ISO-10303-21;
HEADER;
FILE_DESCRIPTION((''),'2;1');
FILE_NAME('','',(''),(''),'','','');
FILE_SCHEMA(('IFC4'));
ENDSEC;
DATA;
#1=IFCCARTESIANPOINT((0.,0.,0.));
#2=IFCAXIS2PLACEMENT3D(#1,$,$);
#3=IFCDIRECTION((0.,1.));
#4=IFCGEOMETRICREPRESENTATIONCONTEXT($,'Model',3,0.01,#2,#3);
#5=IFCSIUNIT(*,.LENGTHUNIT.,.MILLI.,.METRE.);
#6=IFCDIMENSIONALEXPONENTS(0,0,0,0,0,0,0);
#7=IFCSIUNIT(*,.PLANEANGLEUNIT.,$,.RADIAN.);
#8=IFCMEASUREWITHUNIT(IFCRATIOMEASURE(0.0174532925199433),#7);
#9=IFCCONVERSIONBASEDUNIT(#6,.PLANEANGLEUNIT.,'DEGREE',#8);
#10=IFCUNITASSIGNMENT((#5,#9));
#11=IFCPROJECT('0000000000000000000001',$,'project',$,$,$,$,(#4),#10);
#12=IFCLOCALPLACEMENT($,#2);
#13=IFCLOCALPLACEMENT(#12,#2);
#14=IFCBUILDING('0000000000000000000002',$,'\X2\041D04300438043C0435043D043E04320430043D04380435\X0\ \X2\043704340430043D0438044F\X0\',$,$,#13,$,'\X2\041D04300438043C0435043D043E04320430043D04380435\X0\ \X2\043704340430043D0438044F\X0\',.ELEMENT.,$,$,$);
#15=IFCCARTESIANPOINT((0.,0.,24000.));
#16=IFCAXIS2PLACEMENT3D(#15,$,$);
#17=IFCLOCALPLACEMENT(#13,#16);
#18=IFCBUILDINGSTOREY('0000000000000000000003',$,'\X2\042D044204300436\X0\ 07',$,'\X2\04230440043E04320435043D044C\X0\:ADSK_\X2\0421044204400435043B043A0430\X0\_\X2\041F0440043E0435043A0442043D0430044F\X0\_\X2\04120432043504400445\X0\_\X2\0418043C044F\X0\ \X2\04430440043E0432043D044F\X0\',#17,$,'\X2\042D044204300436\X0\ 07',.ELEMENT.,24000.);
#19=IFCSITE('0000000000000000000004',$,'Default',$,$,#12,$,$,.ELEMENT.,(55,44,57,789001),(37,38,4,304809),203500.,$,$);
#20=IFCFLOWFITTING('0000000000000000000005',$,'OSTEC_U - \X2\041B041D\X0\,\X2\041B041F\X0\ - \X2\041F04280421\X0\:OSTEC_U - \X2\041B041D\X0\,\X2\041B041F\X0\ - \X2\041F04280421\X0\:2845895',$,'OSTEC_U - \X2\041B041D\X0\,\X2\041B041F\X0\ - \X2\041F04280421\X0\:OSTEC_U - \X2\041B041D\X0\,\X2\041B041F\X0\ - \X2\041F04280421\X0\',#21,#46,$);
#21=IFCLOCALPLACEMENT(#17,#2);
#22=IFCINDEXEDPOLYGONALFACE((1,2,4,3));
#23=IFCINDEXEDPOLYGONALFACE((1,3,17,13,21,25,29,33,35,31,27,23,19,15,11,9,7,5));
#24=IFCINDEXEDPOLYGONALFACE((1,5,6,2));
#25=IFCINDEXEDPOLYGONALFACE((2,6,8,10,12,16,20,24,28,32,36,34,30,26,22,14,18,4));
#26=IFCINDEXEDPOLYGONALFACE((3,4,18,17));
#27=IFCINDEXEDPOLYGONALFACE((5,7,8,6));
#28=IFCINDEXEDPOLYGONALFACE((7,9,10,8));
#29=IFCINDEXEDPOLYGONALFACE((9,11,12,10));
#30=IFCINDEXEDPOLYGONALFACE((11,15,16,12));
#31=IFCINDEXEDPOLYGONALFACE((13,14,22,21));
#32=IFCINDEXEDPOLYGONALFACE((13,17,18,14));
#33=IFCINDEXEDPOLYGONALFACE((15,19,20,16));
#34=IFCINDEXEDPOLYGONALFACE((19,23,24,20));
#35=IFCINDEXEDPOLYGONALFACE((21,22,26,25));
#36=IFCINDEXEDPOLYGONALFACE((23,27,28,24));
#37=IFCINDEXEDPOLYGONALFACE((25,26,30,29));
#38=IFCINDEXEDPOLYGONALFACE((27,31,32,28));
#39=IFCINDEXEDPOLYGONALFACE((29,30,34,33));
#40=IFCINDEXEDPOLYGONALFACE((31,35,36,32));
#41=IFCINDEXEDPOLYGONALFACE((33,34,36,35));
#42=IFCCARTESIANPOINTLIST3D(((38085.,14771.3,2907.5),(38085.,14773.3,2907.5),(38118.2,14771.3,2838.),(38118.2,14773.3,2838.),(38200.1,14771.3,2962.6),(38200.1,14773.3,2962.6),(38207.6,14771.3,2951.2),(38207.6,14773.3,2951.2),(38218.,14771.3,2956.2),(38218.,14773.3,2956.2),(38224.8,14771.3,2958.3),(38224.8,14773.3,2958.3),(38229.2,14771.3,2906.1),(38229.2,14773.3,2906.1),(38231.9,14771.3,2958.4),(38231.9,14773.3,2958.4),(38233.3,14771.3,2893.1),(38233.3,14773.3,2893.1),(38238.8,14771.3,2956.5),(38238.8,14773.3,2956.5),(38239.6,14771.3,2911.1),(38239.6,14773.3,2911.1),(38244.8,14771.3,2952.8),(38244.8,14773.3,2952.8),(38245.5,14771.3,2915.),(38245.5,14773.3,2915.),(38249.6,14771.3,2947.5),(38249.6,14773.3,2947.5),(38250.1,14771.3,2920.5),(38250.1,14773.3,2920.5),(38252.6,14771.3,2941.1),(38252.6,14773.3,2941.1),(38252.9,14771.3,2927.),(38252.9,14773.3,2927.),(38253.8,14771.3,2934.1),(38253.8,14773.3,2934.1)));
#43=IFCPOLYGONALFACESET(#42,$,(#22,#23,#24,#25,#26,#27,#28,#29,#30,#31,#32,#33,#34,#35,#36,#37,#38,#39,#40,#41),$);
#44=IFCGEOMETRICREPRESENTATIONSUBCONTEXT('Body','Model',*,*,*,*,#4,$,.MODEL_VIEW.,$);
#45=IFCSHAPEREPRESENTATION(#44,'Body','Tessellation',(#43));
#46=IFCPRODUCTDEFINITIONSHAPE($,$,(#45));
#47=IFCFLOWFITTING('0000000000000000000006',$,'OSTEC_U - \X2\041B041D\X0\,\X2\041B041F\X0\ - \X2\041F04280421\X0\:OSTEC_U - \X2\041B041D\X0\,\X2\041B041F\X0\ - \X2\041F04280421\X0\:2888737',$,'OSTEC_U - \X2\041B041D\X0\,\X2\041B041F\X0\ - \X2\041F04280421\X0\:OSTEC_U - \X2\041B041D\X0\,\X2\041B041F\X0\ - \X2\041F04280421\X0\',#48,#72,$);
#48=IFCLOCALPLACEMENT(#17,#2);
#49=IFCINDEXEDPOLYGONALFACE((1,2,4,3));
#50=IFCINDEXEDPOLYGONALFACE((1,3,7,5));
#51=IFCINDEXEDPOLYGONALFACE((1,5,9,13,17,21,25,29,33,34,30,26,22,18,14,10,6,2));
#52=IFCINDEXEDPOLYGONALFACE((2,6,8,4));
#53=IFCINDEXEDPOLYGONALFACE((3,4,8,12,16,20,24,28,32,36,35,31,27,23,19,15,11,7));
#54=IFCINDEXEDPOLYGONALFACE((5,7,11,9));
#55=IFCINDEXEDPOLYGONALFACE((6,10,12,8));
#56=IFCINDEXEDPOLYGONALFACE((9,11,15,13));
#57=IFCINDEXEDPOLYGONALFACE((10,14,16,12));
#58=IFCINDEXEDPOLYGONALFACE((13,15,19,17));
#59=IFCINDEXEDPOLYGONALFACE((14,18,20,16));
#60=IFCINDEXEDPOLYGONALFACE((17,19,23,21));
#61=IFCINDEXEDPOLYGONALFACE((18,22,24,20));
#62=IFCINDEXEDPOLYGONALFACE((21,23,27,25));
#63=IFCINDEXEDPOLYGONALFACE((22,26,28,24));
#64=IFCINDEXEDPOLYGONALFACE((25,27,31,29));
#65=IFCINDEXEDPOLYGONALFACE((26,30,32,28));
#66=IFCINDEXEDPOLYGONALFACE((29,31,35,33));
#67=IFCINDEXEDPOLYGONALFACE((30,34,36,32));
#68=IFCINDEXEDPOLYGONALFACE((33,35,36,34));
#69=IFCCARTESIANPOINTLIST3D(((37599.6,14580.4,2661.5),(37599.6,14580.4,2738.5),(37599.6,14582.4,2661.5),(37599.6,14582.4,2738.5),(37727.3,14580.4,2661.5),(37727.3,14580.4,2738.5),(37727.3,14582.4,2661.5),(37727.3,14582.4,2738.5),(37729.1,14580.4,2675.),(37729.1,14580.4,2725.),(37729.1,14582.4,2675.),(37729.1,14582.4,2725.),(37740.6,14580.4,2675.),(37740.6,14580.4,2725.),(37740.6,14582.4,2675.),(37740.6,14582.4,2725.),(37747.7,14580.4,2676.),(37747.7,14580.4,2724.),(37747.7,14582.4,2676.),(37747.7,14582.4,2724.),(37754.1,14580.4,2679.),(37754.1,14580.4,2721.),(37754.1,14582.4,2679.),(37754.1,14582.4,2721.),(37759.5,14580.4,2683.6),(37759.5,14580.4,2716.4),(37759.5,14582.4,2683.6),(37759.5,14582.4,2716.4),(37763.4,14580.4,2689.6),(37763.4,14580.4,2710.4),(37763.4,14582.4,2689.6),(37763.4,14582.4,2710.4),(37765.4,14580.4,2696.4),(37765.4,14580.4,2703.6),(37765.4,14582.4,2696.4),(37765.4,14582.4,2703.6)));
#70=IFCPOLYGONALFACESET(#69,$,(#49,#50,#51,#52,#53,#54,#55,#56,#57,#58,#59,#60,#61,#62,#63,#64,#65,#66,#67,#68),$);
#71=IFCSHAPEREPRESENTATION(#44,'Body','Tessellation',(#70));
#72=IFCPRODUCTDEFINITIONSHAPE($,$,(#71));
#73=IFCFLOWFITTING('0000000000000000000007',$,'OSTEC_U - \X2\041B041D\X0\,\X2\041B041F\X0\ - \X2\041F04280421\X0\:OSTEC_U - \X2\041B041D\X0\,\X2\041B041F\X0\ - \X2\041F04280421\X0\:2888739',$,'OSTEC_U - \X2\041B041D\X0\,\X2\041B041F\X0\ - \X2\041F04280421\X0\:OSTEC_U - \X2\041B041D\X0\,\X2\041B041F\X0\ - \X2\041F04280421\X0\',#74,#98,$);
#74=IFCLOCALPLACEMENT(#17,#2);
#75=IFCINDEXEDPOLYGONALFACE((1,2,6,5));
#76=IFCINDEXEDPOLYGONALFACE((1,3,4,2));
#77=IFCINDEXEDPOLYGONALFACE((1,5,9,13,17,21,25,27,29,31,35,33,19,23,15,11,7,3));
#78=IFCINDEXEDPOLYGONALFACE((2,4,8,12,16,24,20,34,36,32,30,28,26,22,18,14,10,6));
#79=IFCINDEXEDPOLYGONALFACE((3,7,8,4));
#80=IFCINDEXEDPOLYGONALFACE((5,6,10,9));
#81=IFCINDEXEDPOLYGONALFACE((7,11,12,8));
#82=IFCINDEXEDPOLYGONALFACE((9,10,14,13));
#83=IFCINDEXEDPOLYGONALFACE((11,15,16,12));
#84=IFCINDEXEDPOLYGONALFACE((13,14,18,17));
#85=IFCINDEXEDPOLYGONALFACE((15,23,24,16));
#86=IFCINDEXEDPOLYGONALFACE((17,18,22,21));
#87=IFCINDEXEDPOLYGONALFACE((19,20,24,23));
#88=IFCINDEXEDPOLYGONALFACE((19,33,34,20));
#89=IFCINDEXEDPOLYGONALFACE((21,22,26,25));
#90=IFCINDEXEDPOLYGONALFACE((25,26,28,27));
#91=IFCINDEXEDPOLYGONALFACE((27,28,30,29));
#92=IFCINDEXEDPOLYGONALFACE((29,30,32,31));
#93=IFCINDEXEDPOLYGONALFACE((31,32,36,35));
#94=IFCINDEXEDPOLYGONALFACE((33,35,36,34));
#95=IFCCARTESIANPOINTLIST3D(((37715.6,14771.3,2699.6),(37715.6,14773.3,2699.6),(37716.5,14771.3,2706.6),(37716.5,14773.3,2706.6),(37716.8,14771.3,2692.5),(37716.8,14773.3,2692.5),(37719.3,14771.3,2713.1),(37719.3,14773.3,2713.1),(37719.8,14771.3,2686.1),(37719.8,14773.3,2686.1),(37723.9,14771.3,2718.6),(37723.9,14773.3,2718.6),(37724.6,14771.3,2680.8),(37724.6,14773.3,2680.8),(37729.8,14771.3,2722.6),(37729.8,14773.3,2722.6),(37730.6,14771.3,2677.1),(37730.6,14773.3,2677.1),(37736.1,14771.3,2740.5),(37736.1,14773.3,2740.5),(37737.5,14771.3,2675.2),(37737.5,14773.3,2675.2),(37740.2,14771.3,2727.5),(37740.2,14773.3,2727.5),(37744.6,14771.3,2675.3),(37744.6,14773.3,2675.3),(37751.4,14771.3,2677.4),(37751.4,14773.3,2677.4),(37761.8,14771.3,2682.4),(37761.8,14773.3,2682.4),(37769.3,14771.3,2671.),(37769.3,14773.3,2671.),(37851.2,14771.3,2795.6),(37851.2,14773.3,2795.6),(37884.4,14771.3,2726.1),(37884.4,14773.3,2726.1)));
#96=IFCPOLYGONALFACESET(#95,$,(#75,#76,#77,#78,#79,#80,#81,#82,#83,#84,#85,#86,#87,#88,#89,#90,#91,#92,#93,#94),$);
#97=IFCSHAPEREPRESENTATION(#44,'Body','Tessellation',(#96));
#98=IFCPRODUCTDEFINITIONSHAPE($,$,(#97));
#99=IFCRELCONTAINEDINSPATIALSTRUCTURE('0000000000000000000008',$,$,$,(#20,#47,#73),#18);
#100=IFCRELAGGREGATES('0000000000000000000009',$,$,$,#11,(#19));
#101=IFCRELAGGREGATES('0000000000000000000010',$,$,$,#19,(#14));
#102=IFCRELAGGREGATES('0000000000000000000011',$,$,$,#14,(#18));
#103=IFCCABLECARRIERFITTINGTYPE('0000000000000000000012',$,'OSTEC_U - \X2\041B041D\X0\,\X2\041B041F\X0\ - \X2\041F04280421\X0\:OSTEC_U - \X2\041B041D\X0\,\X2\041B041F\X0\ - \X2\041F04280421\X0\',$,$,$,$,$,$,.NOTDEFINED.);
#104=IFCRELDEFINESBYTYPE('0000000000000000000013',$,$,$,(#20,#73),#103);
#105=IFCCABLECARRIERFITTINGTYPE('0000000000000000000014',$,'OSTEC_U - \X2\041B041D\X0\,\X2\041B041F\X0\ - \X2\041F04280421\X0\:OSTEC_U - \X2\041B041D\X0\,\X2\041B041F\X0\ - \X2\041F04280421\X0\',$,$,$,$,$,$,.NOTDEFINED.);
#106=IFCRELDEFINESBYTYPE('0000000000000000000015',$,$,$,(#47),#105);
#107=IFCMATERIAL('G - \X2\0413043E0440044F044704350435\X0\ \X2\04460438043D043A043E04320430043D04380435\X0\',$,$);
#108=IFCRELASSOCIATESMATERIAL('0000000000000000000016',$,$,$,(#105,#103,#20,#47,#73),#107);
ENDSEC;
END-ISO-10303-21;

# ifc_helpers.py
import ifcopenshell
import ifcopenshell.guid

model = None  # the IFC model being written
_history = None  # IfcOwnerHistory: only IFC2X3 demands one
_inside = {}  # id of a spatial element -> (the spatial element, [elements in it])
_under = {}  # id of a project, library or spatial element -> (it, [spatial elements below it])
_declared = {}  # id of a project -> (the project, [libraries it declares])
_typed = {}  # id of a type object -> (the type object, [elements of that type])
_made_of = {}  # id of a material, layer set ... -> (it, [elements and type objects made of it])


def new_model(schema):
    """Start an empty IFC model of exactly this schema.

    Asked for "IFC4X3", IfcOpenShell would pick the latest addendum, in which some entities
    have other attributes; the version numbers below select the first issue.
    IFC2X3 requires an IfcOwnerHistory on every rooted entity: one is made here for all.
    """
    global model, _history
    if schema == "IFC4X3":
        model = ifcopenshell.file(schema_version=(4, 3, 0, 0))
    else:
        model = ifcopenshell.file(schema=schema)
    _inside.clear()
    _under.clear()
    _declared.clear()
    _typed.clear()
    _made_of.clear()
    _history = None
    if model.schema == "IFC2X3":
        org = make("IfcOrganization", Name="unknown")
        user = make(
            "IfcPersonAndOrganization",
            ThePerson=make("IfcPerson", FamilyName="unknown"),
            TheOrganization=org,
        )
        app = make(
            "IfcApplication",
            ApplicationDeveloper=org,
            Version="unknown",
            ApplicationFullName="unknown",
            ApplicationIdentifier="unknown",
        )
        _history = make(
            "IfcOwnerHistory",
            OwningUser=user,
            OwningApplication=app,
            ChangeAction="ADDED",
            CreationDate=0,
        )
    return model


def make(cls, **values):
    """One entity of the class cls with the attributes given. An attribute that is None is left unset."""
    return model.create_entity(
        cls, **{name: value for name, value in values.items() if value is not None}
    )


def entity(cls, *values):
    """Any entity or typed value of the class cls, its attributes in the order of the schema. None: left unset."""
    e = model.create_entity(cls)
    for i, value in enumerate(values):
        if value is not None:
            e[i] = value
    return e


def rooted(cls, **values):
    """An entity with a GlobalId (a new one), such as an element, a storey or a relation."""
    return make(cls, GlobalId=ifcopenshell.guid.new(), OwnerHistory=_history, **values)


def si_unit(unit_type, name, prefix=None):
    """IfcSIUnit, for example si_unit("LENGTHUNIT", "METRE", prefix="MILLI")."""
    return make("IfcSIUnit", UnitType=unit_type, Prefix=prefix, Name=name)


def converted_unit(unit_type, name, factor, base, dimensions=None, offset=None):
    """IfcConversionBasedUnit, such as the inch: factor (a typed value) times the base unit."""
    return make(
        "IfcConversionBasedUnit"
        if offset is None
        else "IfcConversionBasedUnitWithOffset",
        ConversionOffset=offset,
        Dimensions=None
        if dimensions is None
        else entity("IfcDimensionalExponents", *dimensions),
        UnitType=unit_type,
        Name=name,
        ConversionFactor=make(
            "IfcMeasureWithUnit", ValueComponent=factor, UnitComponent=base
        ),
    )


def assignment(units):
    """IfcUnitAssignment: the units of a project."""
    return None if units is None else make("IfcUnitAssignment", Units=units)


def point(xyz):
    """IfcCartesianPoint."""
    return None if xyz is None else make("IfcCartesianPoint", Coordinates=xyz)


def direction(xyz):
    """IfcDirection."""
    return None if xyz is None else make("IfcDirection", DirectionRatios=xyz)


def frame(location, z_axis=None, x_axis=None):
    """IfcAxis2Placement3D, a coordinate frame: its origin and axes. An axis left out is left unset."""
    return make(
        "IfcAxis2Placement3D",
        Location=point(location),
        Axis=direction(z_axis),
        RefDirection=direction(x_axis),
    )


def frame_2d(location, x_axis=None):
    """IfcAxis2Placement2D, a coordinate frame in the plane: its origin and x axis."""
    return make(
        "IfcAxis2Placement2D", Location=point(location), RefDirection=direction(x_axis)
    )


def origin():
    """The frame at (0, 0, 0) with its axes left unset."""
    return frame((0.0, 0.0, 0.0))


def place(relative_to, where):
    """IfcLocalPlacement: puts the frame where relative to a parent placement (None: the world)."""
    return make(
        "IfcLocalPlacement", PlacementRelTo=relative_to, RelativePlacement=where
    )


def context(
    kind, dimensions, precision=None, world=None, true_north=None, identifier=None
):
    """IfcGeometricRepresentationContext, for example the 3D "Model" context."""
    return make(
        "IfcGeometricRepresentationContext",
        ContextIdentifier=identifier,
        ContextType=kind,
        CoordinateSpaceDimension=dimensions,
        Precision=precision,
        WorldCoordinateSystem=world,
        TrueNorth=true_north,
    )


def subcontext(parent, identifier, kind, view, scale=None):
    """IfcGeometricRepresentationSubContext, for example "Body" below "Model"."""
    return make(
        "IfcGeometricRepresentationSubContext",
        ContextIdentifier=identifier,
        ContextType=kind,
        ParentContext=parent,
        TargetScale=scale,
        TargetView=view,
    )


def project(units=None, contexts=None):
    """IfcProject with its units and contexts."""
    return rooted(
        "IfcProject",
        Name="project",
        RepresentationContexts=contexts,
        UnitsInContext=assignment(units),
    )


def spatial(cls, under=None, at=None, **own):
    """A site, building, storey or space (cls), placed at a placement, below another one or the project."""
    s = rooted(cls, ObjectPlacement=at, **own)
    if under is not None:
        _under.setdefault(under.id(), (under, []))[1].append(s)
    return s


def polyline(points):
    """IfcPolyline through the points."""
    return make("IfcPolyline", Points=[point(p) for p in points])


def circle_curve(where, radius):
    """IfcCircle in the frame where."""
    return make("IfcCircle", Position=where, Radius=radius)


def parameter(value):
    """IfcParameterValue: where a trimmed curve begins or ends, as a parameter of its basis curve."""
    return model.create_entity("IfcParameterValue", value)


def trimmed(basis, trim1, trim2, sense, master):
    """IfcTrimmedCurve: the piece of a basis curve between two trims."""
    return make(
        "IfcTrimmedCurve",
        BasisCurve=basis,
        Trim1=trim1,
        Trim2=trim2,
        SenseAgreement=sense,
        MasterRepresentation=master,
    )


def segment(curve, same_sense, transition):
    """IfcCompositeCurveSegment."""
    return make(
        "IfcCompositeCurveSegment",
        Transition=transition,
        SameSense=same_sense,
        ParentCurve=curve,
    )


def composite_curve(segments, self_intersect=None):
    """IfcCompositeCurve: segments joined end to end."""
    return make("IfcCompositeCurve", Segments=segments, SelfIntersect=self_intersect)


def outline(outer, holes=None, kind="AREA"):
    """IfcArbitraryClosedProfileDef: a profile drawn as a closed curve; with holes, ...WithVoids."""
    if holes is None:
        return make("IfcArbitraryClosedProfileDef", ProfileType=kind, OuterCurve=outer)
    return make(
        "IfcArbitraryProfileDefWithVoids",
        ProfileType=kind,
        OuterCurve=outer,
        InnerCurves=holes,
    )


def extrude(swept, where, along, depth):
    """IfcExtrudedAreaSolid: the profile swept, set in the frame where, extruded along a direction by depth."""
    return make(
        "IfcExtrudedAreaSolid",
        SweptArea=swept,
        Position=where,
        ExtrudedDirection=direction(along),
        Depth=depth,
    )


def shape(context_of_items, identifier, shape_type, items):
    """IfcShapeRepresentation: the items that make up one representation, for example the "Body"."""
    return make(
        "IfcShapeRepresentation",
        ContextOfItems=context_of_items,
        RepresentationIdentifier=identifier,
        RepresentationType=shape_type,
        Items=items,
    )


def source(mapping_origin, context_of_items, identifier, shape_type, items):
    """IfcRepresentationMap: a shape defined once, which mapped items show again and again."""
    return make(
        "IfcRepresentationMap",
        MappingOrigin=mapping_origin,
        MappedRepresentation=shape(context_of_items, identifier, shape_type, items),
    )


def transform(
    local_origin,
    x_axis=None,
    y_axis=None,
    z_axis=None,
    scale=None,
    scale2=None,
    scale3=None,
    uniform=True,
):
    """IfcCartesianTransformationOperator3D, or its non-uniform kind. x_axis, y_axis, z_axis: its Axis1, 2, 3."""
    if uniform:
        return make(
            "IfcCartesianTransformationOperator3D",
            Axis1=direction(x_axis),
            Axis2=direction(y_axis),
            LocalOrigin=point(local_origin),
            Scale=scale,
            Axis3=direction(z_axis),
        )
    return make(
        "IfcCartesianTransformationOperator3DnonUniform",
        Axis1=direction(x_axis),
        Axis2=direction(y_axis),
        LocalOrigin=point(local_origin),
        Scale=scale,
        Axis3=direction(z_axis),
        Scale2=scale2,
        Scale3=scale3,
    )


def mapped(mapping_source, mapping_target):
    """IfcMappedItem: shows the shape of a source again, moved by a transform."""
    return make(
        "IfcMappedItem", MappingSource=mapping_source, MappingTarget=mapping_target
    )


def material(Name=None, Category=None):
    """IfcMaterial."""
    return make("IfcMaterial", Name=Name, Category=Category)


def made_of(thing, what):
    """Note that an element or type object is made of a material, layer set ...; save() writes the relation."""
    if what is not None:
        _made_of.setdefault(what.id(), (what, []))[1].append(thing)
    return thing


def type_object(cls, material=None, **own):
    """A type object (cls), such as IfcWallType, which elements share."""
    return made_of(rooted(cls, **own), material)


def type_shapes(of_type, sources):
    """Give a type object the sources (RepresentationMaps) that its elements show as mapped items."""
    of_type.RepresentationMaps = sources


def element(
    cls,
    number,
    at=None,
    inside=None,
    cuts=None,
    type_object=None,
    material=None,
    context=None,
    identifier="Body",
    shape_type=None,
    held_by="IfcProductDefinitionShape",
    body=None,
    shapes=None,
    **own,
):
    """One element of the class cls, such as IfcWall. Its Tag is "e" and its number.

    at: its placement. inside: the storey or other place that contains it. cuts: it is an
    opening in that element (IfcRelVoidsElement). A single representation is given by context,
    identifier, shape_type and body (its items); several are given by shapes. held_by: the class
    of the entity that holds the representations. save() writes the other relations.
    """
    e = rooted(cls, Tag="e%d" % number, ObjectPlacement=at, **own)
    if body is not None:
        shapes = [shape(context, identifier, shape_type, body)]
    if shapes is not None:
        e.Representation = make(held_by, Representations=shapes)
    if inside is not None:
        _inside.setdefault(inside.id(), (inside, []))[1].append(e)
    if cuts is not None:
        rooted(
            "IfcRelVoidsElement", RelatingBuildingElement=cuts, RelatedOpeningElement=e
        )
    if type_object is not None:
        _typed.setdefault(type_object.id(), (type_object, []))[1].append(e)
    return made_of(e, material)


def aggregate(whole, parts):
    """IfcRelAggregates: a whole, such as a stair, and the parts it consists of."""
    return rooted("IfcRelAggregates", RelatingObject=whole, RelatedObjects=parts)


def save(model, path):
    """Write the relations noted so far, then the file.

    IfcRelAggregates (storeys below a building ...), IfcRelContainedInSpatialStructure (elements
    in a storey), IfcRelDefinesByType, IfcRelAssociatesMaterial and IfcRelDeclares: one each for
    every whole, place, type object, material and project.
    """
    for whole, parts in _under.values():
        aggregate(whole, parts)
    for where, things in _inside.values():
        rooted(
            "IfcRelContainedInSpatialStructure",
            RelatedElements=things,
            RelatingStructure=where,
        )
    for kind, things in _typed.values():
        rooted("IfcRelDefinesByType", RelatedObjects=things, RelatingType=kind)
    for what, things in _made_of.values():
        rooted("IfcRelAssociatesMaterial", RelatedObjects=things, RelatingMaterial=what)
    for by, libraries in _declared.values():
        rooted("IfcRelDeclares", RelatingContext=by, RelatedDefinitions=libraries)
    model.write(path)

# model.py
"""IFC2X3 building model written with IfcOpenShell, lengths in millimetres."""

from ifc_helpers import new_model, entity, si_unit, converted_unit, direction, frame, frame_2d, origin, place, context, subcontext, project, spatial, polyline, circle_curve, parameter, trimmed, segment, composite_curve, outline, extrude, source, transform, mapped, material, type_object, type_shapes, element, save


model = new_model("IFC2X3")

# Units and contexts
model_context = context("Model", 3, precision=0.01, world=origin(), true_north=direction((0.0, 1.0)))
body_context = subcontext(model_context, "Body", "Model", "MODEL_VIEW")
ifc_project = project(units=[si_unit("LENGTHUNIT", "METRE", prefix="MILLI"), converted_unit("PLANEANGLEUNIT", "DEGREE", entity("IfcRatioMeasure", 0.0174532925199433), si_unit("PLANEANGLEUNIT", "RADIAN"), dimensions=[0, 0, 0, 0, 0, 0, 0])], contexts=[model_context])

# Site, building, storey
site_placement = place(None, origin())
site = spatial("IfcSite", under=ifc_project, at=site_placement, Name="Default", CompositionType="ELEMENT", RefLatitude=(55, 44, 57, 789001), RefLongitude=(37, 38, 4, 304809), RefElevation=203500.0)
building_placement = place(site_placement, origin())
building = spatial("IfcBuilding", under=site, at=building_placement, Name="Наименование здания", LongName="Наименование здания", CompositionType="ELEMENT")
storey_placement = place(building_placement, frame((0.0, 0.0, 24000.0)))
storey = spatial("IfcBuildingStorey", under=building, at=storey_placement, Name="Этаж 07", ObjectType="Уровень:ADSK_Стрелка_Проектная_Вверх_Имя уровня", LongName="Этаж 07", CompositionType="ELEMENT", Elevation=24000.0)

# Flow fittings
ifc_material_1 = material(Name="G - Горячее цинкование")
cable_carrier_fitting_type_1 = type_object("IfcCableCarrierFittingType", Name="OSTEC_U - ЛН,ЛП - ПШС:OSTEC_U - ЛН,ЛП - ПШС", PredefinedType="NOTDEFINED", material=ifc_material_1)
shared_shape_1 = source(origin(), body_context, "Body", "SweptSolid", [
    extrude(outline(composite_curve([segment(trimmed(circle_curve(frame_2d((-41.5, 0.0), x_axis=(1.0, 0.0)), 25.0), [parameter(90.0)], [parameter(270.0)], True, "PARAMETER"), True, "CONTINUOUS"), segment(polyline([(-41.5, -25.0), (-30.0, -25.0)]), True, "CONTINUOUS"), segment(polyline([(-30.0, -25.0), (-28.1, -38.5)]), True, "CONTINUOUS"), segment(polyline([(-28.1, -38.5), (99.5, -38.5)]), True, "CONTINUOUS"), segment(polyline([(99.5, -38.5), (99.5, 38.5)]), True, "CONTINUOUS"), segment(polyline([(99.5, 38.5), (-28.1, 38.5)]), True, "CONTINUOUS"), segment(polyline([(-28.1, 38.5), (-30.0, 25.0)]), True, "CONTINUOUS"), segment(polyline([(-30.0, 25.0), (-41.5, 25.0)]), True, "CONTINUOUS")], self_intersect=False)), frame((41.5, 0.0, 0.0)), (0.0, 0.0, 1.0), 2.0),
])
type_shapes(cable_carrier_fitting_type_1, [shared_shape_1])
cable_carrier_fitting_type_2 = type_object("IfcCableCarrierFittingType", Name="OSTEC_U - ЛН,ЛП - ПШС:OSTEC_U - ЛН,ЛП - ПШС", PredefinedType="NOTDEFINED", material=ifc_material_1)
type_shapes(cable_carrier_fitting_type_2, [shared_shape_1])
flow_fitting_1_placement = place(storey_placement, frame((38228.8, 14771.3, 2933.6), z_axis=(0.0, 1.0, 0.0), x_axis=(-0.90203, 0.0, -0.431673)))
element("IfcFlowFitting", 1, at=flow_fitting_1_placement, inside=storey, type_object=cable_carrier_fitting_type_2, material=ifc_material_1, Name="OSTEC_U - ЛН,ЛП - ПШС:OSTEC_U - ЛН,ЛП - ПШС:2845895", ObjectType="OSTEC_U - ЛН,ЛП - ПШС:OSTEC_U - ЛН,ЛП - ПШС", context=body_context, shape_type="MappedRepresentation", body=[
    mapped(shared_shape_1, transform((0.0, 0.0, 0.0), scale=1.0)),
])
flow_fitting_2_placement = place(storey_placement, frame((37740.6, 14582.4, 2700.0), z_axis=(0.0, -1.0, 0.0), x_axis=(-1.0, 0.0, 0.0)))
element("IfcFlowFitting", 2, at=flow_fitting_2_placement, inside=storey, type_object=cable_carrier_fitting_type_1, material=ifc_material_1, Name="OSTEC_U - ЛН,ЛП - ПШС:OSTEC_U - ЛН,ЛП - ПШС:2888737", ObjectType="OSTEC_U - ЛН,ЛП - ПШС:OSTEC_U - ЛН,ЛП - ПШС", context=body_context, shape_type="MappedRepresentation", body=[
    mapped(shared_shape_1, transform((0.0, 0.0, 0.0), scale=1.0)),
])
flow_fitting_3_placement = place(storey_placement, frame((37740.6, 14771.3, 2700.0), z_axis=(0.0, 1.0, 0.0), x_axis=(0.90203, 0.0, 0.431673)))
element("IfcFlowFitting", 3, at=flow_fitting_3_placement, inside=storey, type_object=cable_carrier_fitting_type_2, material=ifc_material_1, Name="OSTEC_U - ЛН,ЛП - ПШС:OSTEC_U - ЛН,ЛП - ПШС:2888739", ObjectType="OSTEC_U - ЛН,ЛП - ПШС:OSTEC_U - ЛН,ЛП - ПШС", context=body_context, shape_type="MappedRepresentation", body=[
    mapped(shared_shape_1, transform((0.0, 0.0, 0.0), scale=1.0)),
])

save(model, "model.ifc")
